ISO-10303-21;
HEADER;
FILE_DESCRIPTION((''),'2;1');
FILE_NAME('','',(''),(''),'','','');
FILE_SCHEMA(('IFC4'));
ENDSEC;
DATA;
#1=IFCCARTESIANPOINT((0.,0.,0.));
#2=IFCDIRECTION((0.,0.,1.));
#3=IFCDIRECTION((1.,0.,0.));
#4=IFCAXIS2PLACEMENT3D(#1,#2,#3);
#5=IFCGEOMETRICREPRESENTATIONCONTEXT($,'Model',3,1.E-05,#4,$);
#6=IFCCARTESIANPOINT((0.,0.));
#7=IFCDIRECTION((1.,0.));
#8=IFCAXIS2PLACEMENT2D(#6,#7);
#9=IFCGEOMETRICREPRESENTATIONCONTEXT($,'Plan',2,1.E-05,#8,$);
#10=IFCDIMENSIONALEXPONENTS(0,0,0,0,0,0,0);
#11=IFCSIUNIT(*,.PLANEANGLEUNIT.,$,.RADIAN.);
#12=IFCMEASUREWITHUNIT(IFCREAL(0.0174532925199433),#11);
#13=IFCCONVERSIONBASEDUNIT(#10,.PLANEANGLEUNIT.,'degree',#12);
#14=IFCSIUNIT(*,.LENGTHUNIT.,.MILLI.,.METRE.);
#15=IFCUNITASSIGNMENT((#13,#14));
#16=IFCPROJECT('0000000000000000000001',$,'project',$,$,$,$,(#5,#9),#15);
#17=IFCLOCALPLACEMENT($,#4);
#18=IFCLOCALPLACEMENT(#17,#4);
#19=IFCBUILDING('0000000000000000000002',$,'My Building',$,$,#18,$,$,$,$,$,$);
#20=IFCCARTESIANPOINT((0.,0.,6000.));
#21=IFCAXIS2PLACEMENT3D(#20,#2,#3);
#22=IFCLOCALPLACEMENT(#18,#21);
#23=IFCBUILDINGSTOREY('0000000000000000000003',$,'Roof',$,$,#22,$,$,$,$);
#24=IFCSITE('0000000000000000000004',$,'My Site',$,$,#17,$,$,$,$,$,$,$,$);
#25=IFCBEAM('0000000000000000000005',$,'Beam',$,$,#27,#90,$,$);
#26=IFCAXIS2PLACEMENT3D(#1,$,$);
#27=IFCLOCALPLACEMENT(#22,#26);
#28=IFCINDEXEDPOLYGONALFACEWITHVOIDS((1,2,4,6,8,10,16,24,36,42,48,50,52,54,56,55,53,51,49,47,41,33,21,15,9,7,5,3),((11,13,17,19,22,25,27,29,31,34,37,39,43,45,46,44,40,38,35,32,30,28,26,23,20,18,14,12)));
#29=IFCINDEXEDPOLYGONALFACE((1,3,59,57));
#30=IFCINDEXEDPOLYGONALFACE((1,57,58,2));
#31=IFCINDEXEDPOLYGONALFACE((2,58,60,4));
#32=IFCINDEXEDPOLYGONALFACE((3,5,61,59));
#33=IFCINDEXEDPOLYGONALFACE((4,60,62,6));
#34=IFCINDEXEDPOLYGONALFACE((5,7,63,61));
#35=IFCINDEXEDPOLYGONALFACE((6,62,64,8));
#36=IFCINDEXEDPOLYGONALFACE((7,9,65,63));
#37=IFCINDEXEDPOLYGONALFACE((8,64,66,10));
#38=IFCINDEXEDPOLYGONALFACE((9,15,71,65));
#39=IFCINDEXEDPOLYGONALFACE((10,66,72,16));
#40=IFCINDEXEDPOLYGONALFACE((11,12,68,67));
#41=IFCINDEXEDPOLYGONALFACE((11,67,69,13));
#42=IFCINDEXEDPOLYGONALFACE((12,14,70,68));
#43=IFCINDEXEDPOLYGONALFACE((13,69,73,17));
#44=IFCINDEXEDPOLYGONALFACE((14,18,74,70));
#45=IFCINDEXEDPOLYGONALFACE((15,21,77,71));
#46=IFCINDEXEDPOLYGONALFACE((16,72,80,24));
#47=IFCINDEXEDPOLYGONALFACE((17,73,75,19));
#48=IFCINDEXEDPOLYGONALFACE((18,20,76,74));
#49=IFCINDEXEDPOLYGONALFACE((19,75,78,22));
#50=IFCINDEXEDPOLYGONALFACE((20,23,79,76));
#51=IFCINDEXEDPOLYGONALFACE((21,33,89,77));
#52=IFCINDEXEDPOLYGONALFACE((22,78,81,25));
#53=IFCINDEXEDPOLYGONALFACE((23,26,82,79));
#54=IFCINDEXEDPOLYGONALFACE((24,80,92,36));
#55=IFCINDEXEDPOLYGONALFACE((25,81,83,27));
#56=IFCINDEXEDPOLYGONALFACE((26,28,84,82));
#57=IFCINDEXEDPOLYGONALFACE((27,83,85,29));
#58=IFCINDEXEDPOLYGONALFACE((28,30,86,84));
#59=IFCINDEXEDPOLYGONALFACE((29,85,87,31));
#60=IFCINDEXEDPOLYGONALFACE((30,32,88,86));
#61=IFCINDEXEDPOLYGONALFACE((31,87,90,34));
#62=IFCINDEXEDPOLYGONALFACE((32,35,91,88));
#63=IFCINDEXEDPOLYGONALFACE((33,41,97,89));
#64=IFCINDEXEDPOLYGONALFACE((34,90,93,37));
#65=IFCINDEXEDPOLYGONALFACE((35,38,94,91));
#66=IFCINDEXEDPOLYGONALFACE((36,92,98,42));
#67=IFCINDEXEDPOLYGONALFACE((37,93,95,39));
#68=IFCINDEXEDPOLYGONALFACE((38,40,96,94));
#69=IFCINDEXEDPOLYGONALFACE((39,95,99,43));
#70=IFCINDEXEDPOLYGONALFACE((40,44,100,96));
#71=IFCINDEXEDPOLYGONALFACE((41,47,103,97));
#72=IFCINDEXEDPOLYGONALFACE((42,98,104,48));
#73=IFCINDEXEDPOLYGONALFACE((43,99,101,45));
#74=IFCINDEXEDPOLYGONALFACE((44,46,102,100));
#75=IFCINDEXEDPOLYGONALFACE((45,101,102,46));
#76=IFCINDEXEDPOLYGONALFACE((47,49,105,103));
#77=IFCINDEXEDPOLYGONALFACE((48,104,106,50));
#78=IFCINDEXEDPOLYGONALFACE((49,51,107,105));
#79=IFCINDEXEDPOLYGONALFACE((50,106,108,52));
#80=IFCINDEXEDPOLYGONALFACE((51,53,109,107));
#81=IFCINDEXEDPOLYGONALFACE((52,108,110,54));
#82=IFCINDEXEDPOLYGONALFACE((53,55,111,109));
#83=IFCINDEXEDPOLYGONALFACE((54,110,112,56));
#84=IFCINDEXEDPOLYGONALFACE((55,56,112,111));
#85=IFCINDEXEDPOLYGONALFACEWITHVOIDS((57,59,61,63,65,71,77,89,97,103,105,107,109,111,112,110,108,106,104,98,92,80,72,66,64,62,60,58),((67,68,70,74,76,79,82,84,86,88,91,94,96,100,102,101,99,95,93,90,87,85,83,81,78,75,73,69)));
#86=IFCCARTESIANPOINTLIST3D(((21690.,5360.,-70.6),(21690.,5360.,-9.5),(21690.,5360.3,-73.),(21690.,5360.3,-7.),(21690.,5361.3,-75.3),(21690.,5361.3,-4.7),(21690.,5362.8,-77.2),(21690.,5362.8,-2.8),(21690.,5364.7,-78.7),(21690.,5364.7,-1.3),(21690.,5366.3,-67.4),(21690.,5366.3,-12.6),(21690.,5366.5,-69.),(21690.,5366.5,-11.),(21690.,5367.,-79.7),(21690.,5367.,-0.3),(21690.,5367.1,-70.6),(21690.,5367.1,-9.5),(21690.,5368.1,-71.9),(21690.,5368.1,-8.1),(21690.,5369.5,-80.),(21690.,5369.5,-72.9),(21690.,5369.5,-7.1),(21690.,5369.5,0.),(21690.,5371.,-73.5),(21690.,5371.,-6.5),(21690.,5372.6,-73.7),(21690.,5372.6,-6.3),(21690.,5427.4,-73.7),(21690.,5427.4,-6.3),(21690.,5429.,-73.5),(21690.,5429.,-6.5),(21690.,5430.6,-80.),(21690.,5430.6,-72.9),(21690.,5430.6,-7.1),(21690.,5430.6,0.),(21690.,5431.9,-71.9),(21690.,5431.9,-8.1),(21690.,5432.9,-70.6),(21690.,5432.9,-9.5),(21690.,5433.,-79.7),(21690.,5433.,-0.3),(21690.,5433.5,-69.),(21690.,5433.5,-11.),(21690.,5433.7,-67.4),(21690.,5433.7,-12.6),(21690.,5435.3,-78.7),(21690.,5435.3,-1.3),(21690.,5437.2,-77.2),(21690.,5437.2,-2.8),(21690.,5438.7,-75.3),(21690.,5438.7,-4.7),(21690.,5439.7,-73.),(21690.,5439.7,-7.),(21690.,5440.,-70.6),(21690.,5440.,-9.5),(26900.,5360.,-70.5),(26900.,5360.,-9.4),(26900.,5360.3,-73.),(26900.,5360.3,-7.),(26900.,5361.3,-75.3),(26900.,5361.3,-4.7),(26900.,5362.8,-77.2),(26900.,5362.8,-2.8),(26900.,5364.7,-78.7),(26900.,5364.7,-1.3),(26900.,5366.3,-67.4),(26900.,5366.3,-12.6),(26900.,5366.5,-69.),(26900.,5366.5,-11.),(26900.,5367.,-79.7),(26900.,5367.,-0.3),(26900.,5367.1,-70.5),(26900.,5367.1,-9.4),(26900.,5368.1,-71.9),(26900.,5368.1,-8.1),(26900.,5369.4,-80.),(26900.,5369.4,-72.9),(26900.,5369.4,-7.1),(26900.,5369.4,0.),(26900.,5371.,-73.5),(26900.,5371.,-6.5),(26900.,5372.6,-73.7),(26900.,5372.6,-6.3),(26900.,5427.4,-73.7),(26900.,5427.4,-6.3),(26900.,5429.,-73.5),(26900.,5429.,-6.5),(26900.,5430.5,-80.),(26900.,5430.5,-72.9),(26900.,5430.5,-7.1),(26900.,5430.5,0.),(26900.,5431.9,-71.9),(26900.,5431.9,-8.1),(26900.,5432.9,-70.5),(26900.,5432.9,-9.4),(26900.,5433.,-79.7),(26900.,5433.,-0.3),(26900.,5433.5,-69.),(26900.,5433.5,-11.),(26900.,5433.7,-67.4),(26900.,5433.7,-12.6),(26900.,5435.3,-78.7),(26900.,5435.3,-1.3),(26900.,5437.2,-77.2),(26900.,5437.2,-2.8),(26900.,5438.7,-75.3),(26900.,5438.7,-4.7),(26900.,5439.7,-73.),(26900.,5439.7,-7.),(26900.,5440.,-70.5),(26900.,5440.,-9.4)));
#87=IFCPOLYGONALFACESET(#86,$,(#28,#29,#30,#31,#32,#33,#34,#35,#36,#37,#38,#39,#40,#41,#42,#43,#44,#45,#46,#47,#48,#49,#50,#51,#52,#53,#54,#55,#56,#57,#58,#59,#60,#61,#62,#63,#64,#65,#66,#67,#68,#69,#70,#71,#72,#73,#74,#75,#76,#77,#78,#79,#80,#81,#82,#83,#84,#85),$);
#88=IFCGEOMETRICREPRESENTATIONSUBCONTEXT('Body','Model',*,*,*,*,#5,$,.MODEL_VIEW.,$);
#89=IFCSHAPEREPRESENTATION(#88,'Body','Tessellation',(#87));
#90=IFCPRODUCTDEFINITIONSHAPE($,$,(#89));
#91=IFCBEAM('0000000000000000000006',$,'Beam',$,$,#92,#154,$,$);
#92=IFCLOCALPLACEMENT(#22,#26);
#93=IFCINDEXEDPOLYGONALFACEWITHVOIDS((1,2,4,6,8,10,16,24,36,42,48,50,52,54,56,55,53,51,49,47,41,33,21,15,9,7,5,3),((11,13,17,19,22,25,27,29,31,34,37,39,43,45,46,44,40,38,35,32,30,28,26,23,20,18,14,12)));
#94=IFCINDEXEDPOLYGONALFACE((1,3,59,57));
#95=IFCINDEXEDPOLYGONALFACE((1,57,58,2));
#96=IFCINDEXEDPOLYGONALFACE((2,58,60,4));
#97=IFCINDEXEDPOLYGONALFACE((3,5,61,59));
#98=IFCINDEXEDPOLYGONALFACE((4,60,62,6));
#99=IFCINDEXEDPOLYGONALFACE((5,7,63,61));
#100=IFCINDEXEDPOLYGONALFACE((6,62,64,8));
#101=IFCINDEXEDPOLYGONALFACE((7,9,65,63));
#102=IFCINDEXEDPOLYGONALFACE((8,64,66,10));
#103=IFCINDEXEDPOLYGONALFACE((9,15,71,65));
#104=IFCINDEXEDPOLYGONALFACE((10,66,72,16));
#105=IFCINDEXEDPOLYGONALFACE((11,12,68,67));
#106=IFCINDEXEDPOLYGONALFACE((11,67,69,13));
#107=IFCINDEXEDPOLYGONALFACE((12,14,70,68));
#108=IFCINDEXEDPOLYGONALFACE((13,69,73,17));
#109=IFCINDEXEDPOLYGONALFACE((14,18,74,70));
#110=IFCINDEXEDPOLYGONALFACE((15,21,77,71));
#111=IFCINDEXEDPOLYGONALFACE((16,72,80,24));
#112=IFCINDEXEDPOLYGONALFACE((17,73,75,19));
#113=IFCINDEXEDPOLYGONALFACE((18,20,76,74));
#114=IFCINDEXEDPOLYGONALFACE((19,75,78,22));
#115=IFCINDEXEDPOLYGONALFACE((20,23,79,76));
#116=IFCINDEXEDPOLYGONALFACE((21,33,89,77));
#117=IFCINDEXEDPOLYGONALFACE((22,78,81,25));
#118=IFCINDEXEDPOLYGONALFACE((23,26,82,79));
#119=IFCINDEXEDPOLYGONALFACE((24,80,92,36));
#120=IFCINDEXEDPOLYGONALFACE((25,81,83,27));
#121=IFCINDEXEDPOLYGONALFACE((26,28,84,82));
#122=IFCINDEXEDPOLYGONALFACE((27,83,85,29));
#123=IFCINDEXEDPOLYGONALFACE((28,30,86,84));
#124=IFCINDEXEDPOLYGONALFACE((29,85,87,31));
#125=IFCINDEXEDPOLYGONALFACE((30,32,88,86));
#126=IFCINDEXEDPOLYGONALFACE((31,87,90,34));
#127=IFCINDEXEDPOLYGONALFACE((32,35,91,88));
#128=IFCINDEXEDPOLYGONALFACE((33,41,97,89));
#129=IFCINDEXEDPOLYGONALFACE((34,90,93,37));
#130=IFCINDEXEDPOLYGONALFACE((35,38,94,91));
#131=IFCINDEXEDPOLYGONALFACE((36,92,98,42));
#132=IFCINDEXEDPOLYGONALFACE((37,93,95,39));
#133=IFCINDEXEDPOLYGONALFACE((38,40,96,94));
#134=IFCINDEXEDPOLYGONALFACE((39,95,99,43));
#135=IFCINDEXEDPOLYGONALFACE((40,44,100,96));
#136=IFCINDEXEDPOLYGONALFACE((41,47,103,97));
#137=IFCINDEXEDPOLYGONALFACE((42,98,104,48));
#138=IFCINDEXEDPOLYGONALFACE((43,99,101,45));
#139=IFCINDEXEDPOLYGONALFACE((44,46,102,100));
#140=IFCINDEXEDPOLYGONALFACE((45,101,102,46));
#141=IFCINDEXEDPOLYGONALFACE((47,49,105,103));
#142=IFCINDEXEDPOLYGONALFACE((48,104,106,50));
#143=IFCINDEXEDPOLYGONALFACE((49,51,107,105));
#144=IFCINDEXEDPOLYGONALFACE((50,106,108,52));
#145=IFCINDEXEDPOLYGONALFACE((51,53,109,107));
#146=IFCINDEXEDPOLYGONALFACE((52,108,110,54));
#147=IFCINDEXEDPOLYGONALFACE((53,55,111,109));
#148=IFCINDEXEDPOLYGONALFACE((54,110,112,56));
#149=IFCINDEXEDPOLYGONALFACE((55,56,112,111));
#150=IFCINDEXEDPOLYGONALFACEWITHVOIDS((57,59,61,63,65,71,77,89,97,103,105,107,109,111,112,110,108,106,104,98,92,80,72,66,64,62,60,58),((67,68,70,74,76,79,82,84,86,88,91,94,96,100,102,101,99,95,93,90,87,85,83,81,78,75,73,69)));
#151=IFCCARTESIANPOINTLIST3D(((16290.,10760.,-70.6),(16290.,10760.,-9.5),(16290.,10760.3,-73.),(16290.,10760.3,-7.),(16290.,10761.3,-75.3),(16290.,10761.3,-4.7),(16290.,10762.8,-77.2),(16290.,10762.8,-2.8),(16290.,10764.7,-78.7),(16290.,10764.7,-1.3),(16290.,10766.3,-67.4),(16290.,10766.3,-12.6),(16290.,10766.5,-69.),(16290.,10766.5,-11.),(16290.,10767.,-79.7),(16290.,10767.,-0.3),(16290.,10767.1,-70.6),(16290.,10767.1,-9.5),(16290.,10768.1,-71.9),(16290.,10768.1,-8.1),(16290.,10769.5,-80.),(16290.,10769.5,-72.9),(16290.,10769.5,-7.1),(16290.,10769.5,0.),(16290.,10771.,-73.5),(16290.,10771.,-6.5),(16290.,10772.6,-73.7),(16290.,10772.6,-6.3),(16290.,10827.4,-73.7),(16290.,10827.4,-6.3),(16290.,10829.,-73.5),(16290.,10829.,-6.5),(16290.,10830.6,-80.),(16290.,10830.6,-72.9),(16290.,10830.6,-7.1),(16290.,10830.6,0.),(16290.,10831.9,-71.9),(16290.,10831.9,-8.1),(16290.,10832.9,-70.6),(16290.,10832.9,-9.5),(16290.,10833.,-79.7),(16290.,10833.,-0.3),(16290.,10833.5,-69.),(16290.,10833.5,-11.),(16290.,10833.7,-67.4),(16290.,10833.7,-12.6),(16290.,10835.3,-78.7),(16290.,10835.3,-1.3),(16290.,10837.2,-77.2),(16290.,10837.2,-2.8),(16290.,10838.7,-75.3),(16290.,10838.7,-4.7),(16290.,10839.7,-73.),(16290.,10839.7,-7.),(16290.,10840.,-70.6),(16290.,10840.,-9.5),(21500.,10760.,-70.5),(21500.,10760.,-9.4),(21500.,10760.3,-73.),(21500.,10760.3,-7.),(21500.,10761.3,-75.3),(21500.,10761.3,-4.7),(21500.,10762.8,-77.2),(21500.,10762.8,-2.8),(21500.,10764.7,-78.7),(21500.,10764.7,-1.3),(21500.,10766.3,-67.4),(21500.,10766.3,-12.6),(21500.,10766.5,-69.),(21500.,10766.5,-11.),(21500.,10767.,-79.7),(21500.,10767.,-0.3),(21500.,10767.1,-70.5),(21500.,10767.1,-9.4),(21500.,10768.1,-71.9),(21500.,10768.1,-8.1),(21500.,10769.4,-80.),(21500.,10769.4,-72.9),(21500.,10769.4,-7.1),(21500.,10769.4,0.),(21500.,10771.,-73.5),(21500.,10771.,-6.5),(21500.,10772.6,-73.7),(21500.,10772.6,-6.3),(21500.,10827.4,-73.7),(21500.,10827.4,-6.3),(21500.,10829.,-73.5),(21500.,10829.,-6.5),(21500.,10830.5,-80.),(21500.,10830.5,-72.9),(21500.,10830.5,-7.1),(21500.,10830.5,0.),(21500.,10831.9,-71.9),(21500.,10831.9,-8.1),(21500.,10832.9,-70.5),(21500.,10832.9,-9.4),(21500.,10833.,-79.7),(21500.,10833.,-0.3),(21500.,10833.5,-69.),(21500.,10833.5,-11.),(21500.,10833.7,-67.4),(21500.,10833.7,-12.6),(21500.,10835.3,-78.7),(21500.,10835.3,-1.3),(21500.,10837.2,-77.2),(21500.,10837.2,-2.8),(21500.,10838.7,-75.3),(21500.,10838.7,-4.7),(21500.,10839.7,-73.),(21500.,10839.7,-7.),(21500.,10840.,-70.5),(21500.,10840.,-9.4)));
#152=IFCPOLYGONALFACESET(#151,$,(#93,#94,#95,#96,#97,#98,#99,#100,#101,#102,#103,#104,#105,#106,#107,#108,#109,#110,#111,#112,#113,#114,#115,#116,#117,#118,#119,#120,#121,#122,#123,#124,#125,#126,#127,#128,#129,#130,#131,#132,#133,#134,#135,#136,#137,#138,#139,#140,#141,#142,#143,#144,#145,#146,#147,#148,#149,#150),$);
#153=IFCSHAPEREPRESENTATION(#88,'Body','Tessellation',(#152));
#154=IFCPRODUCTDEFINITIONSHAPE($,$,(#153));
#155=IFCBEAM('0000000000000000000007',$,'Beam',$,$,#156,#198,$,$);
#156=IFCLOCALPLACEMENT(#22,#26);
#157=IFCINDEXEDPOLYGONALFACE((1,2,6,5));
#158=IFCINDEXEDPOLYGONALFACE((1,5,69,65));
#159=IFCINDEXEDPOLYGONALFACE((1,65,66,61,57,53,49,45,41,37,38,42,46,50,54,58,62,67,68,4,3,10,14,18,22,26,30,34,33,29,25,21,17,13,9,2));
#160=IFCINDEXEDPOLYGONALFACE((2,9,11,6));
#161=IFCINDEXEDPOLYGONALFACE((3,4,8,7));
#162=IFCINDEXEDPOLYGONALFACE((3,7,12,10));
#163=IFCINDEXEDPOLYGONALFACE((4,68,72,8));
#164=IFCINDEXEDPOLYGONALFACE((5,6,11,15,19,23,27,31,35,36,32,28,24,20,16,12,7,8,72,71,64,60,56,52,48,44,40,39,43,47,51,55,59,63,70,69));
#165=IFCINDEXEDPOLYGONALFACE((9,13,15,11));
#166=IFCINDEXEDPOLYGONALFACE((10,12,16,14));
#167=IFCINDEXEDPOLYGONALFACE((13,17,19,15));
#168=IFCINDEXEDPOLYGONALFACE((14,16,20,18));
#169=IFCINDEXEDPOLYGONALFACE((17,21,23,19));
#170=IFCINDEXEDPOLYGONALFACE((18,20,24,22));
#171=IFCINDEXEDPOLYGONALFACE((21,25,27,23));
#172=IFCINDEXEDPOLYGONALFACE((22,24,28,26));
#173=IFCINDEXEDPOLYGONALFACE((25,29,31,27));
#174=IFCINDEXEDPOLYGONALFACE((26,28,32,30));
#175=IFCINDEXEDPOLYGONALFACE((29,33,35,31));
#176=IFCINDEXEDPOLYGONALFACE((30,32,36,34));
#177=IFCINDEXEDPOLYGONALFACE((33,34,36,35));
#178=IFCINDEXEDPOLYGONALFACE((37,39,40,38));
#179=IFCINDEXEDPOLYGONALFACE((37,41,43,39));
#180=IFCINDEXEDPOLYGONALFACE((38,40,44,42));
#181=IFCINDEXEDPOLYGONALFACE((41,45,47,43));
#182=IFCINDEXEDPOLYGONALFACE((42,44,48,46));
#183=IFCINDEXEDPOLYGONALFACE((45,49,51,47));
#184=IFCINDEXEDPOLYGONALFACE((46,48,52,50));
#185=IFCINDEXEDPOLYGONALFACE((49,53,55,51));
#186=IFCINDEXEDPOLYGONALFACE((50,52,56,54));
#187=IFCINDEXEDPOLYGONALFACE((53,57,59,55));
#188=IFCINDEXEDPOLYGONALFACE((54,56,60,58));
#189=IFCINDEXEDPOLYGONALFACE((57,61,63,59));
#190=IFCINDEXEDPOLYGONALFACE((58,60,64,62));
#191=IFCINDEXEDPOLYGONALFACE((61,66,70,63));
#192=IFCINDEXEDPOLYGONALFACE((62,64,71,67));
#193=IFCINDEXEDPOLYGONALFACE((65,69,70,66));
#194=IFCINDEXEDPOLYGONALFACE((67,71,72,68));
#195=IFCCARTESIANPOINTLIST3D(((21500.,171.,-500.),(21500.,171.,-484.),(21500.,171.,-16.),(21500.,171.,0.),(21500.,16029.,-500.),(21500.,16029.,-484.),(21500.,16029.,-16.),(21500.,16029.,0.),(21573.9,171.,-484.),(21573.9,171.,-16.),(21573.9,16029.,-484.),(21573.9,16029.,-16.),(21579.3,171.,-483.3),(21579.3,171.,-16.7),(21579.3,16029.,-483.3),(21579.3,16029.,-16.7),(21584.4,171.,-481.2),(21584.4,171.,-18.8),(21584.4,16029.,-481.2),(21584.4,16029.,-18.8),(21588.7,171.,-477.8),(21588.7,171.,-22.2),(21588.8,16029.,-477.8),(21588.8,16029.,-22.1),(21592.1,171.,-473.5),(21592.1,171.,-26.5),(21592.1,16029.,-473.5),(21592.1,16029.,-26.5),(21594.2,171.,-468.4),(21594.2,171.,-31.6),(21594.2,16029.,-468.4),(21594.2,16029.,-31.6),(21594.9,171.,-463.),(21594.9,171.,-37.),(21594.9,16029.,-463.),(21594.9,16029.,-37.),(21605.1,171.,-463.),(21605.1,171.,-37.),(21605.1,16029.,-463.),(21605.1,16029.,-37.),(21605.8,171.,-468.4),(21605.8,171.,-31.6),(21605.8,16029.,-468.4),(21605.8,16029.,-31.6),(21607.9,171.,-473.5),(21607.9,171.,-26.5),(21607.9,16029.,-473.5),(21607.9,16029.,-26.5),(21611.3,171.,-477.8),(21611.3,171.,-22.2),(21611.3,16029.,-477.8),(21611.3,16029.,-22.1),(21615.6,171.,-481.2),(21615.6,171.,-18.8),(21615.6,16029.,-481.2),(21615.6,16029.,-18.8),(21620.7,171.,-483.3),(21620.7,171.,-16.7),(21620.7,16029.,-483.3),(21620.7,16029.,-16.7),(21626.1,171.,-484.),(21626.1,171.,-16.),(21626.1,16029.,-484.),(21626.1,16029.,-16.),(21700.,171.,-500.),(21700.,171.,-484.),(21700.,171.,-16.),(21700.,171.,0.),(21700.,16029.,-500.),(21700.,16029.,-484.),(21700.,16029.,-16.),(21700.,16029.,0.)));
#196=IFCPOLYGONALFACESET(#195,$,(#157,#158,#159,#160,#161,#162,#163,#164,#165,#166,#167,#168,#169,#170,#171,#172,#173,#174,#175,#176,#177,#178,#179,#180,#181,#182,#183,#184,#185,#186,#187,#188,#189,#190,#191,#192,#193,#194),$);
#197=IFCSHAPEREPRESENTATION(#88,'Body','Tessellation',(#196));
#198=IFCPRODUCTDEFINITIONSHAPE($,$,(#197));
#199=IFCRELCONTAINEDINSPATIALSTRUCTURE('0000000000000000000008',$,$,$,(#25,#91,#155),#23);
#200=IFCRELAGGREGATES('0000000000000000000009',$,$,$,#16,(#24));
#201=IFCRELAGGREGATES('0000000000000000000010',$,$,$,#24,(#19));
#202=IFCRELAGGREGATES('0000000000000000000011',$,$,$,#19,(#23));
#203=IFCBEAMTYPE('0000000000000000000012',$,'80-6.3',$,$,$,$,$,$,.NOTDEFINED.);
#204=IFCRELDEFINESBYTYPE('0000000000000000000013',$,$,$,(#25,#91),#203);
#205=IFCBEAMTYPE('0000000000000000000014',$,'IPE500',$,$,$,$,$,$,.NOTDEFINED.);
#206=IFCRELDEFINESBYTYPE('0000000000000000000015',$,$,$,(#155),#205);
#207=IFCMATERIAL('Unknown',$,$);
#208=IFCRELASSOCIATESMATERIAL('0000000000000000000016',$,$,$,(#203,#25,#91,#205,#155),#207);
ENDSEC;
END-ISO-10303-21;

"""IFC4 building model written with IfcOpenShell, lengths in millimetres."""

from ifc_helpers import new_model, entity, si_unit, converted_unit, frame, origin_with_axes, origin_2d_with_axis, place, context, subcontext, project, spatial, hollow_rectangle, i_section, extrude, material, material_profile, profile_set, profile_usage, type_object, element, save


model = new_model("IFC4")

# Units and contexts
model_context = context("Model", 3, precision=1e-05, world=origin_with_axes())
plan_context = context("Plan", 2, precision=1e-05, world=origin_2d_with_axis())
body_context = subcontext(model_context, "Body", "Model", "MODEL_VIEW")
ifc_project = project(units=[converted_unit("PLANEANGLEUNIT", "degree", entity("IfcReal", 0.0174532925199433), si_unit("PLANEANGLEUNIT", "RADIAN"), dimensions=[0, 0, 0, 0, 0, 0, 0]), si_unit("LENGTHUNIT", "METRE", prefix="MILLI")], contexts=[model_context, plan_context])

# Site, building, storey
site_placement = place(None, origin_with_axes())
site = spatial("IfcSite", under=ifc_project, at=site_placement, Name="My Site")
building_placement = place(site_placement, origin_with_axes())
building = spatial("IfcBuilding", under=site, at=building_placement, Name="My Building")
storey_placement = place(building_placement, frame((0.0, 0.0, 6000.0), z_axis=(0.0, 0.0, 1.0), x_axis=(1.0, 0.0, 0.0)))
storey = spatial("IfcBuildingStorey", under=building, at=storey_placement, Name="Roof")

# Beams
ifc_material = material(Name="Unknown")
ifc_material_profile_1 = material_profile(ifc_material, hollow_rectangle(XDim=80.0, YDim=80.0, WallThickness=6.3, InnerFilletRadius=6.3, OuterFilletRadius=9.4))
ifc_profile_set_1 = profile_set([ifc_material_profile_1])
beam_type_1 = type_object("IfcBeamType", Name="80-6.3", PredefinedType="NOTDEFINED", material=ifc_profile_set_1)
ifc_profile_usage_1 = profile_usage(ifc_profile_set_1, cardinal=8)
beam_1_placement = place(storey_placement, frame((21690.0, 5400.0, 0.0), z_axis=(1.0, 0.0, 0.0), x_axis=(0.0, 1.0, 0.0)))
element("IfcBeam", 1, at=beam_1_placement, inside=storey, type_object=beam_type_1, material=ifc_profile_usage_1, Name="Beam", context=body_context, shape_type="SweptSolid", body=[
    extrude(hollow_rectangle(XDim=80.0, YDim=80.0, WallThickness=6.3, InnerFilletRadius=6.3, OuterFilletRadius=9.4), frame((0.0, -40.0, 0.0), z_axis=(0.0, 0.0, 1.0), x_axis=(1.0, 0.0, 0.0)), (0.0, 0.0, 1.0), 5210.0),
])
ifc_profile_usage_2 = profile_usage(ifc_profile_set_1, cardinal=8)
beam_2_placement = place(storey_placement, frame((16290.0, 10800.0, 0.0), z_axis=(1.0, 0.0, 0.0), x_axis=(0.0, 1.0, 0.0)))
element("IfcBeam", 2, at=beam_2_placement, inside=storey, type_object=beam_type_1, material=ifc_profile_usage_2, Name="Beam", context=body_context, shape_type="SweptSolid", body=[
    extrude(hollow_rectangle(XDim=80.0, YDim=80.0, WallThickness=6.3, InnerFilletRadius=6.3, OuterFilletRadius=9.4), frame((0.0, -40.0, 0.0), z_axis=(0.0, 0.0, 1.0), x_axis=(1.0, 0.0, 0.0)), (0.0, 0.0, 1.0), 5210.0),
])
ifc_material_profile_2 = material_profile(ifc_material, i_section(OverallWidth=200.0, OverallDepth=500.0, WebThickness=10.2, FlangeThickness=16.0, FilletRadius=21.0))
ifc_profile_set_2 = profile_set([ifc_material_profile_2])
ifc_profile_usage_3 = profile_usage(ifc_profile_set_2, cardinal=8)
beam_type_2 = type_object("IfcBeamType", Name="IPE500", PredefinedType="NOTDEFINED", material=ifc_profile_set_2)
beam_3_placement = place(storey_placement, frame((21600.0, 171.0, 0.0), z_axis=(0.0, 1.0, 0.0), x_axis=(-1.0, 0.0, 0.0)))
element("IfcBeam", 3, at=beam_3_placement, inside=storey, type_object=beam_type_2, material=ifc_profile_usage_3, Name="Beam", context=body_context, shape_type="SweptSolid", body=[
    extrude(i_section(OverallWidth=200.0, OverallDepth=500.0, WebThickness=10.2, FlangeThickness=16.0, FilletRadius=21.0), frame((0.0, -250.0, 0.0), z_axis=(0.0, 0.0, 1.0), x_axis=(1.0, 0.0, 0.0)), (0.0, 0.0, 1.0), 15858.0),
])

save(model, "model.ifc")
